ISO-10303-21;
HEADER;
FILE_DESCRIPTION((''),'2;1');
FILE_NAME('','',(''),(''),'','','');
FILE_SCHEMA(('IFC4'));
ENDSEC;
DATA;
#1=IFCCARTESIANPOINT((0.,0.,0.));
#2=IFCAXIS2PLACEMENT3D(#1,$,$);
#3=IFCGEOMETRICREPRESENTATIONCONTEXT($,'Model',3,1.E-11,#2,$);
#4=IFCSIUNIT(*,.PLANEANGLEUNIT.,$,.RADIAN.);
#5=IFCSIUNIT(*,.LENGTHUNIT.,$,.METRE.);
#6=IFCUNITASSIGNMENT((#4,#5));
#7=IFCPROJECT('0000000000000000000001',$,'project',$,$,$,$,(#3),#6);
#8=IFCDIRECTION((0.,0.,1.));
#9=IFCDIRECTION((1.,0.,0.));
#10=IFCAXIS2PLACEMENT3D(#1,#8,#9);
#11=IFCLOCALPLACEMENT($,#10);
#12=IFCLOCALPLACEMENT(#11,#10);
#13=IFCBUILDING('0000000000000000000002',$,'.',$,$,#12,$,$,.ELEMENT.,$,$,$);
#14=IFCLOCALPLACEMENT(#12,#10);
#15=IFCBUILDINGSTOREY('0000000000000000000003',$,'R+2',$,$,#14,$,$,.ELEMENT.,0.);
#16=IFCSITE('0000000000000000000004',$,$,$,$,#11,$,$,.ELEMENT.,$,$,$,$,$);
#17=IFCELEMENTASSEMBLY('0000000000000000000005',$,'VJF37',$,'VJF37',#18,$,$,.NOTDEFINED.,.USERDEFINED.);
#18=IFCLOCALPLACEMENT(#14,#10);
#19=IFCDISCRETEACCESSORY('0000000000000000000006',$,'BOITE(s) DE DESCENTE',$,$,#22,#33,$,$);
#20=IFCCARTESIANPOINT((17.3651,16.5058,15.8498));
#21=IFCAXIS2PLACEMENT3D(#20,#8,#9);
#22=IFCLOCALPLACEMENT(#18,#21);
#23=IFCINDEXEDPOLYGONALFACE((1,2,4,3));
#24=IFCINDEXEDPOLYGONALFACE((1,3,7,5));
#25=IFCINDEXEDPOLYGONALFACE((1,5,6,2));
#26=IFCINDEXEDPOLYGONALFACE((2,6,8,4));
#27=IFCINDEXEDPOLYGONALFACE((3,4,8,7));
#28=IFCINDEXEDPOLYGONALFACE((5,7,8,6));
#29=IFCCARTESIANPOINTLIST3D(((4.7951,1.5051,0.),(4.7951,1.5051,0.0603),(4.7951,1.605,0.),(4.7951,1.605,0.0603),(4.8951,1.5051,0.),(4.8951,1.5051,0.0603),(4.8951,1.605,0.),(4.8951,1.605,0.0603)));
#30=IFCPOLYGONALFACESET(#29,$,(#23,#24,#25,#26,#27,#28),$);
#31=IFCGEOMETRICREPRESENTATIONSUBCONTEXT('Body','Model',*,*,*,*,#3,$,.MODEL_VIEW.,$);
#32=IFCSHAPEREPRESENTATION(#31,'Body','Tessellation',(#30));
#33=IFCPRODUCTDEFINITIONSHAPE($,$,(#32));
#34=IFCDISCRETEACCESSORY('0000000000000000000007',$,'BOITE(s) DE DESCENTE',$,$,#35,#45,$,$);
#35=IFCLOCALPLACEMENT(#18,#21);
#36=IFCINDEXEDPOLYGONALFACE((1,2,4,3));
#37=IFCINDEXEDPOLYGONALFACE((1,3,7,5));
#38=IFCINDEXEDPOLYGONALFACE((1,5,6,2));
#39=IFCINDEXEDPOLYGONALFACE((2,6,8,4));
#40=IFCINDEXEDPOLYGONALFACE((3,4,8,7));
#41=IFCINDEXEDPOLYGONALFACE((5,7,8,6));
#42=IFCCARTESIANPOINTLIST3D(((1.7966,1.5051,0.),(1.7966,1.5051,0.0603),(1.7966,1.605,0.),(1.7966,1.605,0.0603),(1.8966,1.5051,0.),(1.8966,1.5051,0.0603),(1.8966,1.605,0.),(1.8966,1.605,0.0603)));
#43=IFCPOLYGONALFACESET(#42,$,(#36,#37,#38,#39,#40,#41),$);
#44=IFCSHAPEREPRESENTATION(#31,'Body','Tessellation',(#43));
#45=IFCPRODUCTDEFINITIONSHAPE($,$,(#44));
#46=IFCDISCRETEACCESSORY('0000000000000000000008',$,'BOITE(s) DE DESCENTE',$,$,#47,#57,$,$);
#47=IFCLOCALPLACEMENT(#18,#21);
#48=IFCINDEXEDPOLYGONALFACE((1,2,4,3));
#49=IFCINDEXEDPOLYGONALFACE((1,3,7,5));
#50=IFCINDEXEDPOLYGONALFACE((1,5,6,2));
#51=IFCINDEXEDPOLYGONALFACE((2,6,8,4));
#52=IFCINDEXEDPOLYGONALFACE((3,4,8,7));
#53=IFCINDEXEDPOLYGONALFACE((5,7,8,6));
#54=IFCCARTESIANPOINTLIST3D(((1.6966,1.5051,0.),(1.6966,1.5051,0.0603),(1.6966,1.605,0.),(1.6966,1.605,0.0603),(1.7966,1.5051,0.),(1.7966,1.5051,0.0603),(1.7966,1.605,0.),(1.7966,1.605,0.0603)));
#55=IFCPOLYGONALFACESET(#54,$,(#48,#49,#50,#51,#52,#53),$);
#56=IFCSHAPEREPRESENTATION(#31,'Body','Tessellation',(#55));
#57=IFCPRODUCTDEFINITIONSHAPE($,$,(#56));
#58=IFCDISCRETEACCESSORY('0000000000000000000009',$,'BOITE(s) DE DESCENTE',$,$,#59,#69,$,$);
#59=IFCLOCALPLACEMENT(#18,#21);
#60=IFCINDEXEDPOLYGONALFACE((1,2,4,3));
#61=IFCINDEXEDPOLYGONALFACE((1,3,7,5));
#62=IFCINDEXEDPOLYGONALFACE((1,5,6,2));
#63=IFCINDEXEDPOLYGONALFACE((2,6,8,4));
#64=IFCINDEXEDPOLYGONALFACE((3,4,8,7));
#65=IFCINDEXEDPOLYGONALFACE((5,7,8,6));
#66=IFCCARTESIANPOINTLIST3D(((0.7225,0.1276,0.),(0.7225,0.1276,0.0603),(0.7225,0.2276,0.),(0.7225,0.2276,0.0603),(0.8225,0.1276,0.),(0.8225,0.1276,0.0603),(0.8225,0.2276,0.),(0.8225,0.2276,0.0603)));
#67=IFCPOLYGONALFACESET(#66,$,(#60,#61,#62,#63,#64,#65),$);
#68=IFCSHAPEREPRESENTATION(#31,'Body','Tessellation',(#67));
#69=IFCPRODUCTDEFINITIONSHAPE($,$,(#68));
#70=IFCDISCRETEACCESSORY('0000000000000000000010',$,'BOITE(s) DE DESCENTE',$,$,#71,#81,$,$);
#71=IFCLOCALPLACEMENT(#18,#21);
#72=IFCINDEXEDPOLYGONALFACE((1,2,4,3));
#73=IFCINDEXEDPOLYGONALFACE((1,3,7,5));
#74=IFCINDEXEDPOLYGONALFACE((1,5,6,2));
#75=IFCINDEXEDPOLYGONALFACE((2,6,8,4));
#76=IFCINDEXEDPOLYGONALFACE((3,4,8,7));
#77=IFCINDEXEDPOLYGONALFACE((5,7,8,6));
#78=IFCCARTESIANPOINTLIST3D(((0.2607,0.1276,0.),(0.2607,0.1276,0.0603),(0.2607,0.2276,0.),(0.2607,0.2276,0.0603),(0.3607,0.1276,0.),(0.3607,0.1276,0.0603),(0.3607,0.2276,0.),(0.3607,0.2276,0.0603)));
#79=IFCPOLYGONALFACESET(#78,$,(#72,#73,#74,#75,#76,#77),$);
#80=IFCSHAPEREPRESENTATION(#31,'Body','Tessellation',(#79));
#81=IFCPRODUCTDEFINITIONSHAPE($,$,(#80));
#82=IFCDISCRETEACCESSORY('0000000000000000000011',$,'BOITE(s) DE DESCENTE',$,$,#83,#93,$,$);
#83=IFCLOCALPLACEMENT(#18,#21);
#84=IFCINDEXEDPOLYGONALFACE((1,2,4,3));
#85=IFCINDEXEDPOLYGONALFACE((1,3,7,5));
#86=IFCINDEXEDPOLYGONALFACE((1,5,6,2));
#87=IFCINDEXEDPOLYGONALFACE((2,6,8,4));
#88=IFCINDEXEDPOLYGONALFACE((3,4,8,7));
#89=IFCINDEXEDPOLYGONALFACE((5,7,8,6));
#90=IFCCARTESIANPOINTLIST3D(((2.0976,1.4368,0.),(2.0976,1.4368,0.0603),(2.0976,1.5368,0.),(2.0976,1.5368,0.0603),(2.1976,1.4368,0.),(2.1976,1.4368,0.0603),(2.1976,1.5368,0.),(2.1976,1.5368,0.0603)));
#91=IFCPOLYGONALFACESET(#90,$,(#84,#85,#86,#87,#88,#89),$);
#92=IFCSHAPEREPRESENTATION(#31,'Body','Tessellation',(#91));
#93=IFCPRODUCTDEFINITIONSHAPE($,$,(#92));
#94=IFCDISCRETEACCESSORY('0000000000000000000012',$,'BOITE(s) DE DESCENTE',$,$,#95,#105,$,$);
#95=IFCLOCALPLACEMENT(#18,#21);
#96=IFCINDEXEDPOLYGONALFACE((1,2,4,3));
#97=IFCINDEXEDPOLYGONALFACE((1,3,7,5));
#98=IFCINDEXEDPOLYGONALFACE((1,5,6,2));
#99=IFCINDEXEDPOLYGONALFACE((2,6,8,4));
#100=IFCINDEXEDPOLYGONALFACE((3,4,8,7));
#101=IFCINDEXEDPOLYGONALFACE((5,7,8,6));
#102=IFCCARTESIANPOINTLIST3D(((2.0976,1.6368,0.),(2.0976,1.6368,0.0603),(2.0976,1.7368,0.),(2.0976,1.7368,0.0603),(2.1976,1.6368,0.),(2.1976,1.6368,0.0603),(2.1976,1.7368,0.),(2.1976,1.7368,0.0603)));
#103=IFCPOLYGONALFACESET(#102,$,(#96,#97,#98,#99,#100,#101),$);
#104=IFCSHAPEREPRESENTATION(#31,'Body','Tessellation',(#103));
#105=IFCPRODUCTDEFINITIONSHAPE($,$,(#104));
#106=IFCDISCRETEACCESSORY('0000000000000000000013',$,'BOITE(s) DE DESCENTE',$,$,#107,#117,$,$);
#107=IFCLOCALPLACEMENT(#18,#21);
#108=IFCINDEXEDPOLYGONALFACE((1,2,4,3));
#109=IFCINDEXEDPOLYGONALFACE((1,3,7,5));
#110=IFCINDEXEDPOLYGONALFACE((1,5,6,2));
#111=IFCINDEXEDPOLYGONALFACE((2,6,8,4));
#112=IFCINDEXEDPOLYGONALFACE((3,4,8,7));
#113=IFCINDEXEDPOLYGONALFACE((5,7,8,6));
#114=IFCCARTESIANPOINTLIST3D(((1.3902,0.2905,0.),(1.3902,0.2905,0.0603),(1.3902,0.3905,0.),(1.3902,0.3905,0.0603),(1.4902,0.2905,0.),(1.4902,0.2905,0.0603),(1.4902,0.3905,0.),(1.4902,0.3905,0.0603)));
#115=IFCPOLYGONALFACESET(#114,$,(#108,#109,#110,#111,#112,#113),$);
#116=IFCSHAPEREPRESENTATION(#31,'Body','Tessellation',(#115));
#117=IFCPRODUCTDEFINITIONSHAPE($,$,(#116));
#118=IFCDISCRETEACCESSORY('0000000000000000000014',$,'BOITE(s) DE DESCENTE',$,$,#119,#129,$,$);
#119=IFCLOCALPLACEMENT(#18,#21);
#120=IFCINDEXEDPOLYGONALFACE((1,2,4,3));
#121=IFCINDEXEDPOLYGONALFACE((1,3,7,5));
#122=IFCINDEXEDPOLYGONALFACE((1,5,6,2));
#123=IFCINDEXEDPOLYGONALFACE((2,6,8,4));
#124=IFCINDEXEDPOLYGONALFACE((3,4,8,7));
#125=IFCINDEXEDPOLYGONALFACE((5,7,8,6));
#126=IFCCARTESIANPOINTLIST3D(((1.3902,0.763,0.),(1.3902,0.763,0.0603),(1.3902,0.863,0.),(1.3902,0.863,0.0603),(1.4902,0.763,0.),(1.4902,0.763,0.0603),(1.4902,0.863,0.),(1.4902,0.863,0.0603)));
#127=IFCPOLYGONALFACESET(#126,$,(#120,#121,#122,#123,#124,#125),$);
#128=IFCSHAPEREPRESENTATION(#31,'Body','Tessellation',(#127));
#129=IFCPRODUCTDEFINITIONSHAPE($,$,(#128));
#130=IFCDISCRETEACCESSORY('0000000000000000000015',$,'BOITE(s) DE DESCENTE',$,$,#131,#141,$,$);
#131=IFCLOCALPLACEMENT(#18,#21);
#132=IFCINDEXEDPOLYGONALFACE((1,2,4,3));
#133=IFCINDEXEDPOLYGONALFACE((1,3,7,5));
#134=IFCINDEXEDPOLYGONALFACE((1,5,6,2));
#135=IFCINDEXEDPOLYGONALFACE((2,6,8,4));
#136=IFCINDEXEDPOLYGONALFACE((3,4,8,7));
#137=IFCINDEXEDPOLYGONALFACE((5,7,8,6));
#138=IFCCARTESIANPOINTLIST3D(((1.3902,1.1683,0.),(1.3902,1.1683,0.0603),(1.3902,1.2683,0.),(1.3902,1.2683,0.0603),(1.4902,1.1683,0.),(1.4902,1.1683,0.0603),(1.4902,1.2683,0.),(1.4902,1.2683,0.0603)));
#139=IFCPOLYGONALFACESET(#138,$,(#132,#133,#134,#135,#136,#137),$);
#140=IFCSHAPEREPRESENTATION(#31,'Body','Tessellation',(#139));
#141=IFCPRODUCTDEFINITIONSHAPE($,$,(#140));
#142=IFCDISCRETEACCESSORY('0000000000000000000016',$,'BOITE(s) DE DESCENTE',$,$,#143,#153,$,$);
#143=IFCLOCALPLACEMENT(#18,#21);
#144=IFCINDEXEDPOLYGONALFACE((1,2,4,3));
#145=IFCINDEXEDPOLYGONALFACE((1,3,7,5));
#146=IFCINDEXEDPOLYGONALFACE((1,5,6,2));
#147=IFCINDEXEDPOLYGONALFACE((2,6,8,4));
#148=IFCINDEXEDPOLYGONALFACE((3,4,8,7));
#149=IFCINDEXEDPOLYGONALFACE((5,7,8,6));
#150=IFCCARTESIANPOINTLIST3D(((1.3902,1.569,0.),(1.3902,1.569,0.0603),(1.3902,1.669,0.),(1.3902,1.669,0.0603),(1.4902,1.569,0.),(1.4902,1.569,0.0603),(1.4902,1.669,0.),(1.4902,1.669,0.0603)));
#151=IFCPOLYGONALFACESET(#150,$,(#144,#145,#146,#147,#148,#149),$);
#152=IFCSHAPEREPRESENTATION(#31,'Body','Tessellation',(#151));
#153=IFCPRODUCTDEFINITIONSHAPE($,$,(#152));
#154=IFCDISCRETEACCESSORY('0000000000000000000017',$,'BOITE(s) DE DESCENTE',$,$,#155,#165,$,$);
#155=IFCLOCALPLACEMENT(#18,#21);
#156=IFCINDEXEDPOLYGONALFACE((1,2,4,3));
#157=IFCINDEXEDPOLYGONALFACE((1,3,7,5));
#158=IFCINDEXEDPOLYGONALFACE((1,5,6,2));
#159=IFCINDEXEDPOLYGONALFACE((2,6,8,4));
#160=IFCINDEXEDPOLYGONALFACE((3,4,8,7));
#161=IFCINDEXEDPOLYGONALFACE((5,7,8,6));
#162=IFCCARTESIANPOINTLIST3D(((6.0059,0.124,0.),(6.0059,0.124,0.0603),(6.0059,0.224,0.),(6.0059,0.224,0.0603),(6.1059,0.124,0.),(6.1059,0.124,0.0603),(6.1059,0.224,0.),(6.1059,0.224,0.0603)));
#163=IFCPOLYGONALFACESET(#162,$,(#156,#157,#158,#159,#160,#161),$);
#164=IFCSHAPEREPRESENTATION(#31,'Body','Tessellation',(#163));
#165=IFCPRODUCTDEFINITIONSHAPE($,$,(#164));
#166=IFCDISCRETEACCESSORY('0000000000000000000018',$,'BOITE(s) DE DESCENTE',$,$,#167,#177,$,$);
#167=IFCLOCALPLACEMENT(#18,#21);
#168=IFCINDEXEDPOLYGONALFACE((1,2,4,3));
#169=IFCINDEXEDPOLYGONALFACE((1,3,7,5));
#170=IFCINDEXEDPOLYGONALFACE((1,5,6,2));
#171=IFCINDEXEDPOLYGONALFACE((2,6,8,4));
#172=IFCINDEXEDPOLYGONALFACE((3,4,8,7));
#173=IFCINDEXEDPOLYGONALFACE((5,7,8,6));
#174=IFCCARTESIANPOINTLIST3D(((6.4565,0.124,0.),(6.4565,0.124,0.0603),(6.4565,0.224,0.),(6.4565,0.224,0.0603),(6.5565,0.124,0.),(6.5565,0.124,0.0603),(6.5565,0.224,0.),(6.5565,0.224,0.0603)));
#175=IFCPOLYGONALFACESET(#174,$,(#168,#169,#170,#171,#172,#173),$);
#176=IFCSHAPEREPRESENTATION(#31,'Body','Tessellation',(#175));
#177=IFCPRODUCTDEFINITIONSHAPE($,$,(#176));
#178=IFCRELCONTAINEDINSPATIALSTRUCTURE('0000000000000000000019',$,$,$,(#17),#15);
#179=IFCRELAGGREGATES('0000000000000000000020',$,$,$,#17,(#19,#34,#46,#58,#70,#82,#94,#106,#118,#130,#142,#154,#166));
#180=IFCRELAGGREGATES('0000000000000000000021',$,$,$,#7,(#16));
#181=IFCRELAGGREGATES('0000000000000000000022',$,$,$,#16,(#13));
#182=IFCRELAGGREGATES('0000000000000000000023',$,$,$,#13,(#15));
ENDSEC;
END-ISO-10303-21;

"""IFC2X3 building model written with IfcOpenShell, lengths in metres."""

from ifc_helpers import new_model, si_unit, frame, origin, origin_with_axes, place, context, subcontext, project, spatial, polyline, outline, extrude, element, aggregate, save


model = new_model("IFC2X3")

# Units and contexts
model_context = context("Model", 3, precision=1e-11, world=origin())
body_context = subcontext(model_context, "Body", "Model", "MODEL_VIEW")
ifc_project = project(units=[si_unit("PLANEANGLEUNIT", "RADIAN"), si_unit("LENGTHUNIT", "METRE")], contexts=[model_context])

# Site, building, storey
site_placement = place(None, origin_with_axes())
site = spatial("IfcSite", under=ifc_project, at=site_placement, CompositionType="ELEMENT")
building_placement = place(site_placement, origin_with_axes())
building = spatial("IfcBuilding", under=site, at=building_placement, Name=".", CompositionType="ELEMENT")
storey_placement = place(building_placement, origin_with_axes())
storey = spatial("IfcBuildingStorey", under=building, at=storey_placement, Name="R+2", CompositionType="ELEMENT", Elevation=0.0)

# Element assembly, discrete accessories
assembly_placement = place(storey_placement, origin_with_axes())
assembly = element("IfcElementAssembly", 1, at=assembly_placement, inside=storey, Name="VJF37", ObjectType="VJF37", AssemblyPlace="NOTDEFINED", PredefinedType="USERDEFINED")
discrete_accessory_1_placement = place(assembly_placement, frame((17.3651, 16.5058, 15.8498), z_axis=(0.0, 0.0, 1.0), x_axis=(1.0, 0.0, 0.0)))
discrete_accessory_1 = element("IfcDiscreteAccessory", 2, at=discrete_accessory_1_placement, Name="BOITE(s) DE DESCENTE", context=body_context, shape_type="SweptSolid", body=[
    extrude(outline(polyline([(1.505, -4.7951), (1.505, -4.8951), (1.6051, -4.8951), (1.6051, -4.7951), (1.505, -4.7951)])), frame((0.0, 0.0, 0.0), z_axis=(0.0, 0.0, 1.0), x_axis=(0.0, 1.0, 0.0)), (0.0, 0.0, 1.0), 0.0603),
])
discrete_accessory_2_placement = place(assembly_placement, frame((17.3651, 16.5058, 15.8498), z_axis=(0.0, 0.0, 1.0), x_axis=(1.0, 0.0, 0.0)))
discrete_accessory_2 = element("IfcDiscreteAccessory", 3, at=discrete_accessory_2_placement, Name="BOITE(s) DE DESCENTE", context=body_context, shape_type="SweptSolid", body=[
    extrude(outline(polyline([(1.505, -1.7966), (1.505, -1.8966), (1.6051, -1.8966), (1.6051, -1.7966), (1.505, -1.7966)])), frame((0.0, 0.0, 0.0), z_axis=(0.0, 0.0, 1.0), x_axis=(0.0, 1.0, 0.0)), (0.0, 0.0, 1.0), 0.0603),
])
discrete_accessory_3_placement = place(assembly_placement, frame((17.3651, 16.5058, 15.8498), z_axis=(0.0, 0.0, 1.0), x_axis=(1.0, 0.0, 0.0)))
discrete_accessory_3 = element("IfcDiscreteAccessory", 4, at=discrete_accessory_3_placement, Name="BOITE(s) DE DESCENTE", context=body_context, shape_type="SweptSolid", body=[
    extrude(outline(polyline([(1.505, -1.6966), (1.505, -1.7966), (1.6051, -1.7966), (1.6051, -1.6966), (1.505, -1.6966)])), frame((0.0, 0.0, 0.0), z_axis=(0.0, 0.0, 1.0), x_axis=(0.0, 1.0, 0.0)), (0.0, 0.0, 1.0), 0.0603),
])
discrete_accessory_4_placement = place(assembly_placement, frame((17.3651, 16.5058, 15.8498), z_axis=(0.0, 0.0, 1.0), x_axis=(1.0, 0.0, 0.0)))
discrete_accessory_4 = element("IfcDiscreteAccessory", 5, at=discrete_accessory_4_placement, Name="BOITE(s) DE DESCENTE", context=body_context, shape_type="SweptSolid", body=[
    extrude(outline(polyline([(0.1276, -0.7225), (0.1276, -0.8225), (0.2276, -0.8225), (0.2276, -0.7225), (0.1276, -0.7225)])), frame((0.0, 0.0, 0.0), z_axis=(0.0, 0.0, 1.0), x_axis=(0.0, 1.0, 0.0)), (0.0, 0.0, 1.0), 0.0603),
])
discrete_accessory_5_placement = place(assembly_placement, frame((17.3651, 16.5058, 15.8498), z_axis=(0.0, 0.0, 1.0), x_axis=(1.0, 0.0, 0.0)))
discrete_accessory_5 = element("IfcDiscreteAccessory", 6, at=discrete_accessory_5_placement, Name="BOITE(s) DE DESCENTE", context=body_context, shape_type="SweptSolid", body=[
    extrude(outline(polyline([(0.1276, -0.2607), (0.1276, -0.3607), (0.2276, -0.3607), (0.2276, -0.2607), (0.1276, -0.2607)])), frame((0.0, 0.0, 0.0), z_axis=(0.0, 0.0, 1.0), x_axis=(0.0, 1.0, 0.0)), (0.0, 0.0, 1.0), 0.0603),
])
discrete_accessory_6_placement = place(assembly_placement, frame((17.3651, 16.5058, 15.8498), z_axis=(0.0, 0.0, 1.0), x_axis=(1.0, 0.0, 0.0)))
discrete_accessory_6 = element("IfcDiscreteAccessory", 7, at=discrete_accessory_6_placement, Name="BOITE(s) DE DESCENTE", context=body_context, shape_type="SweptSolid", body=[
    extrude(outline(polyline([(1.4368, -2.0976), (1.4368, -2.1976), (1.5368, -2.1976), (1.5368, -2.0976), (1.4368, -2.0976)])), frame((0.0, 0.0, 0.0), z_axis=(0.0, 0.0, 1.0), x_axis=(0.0, 1.0, 0.0)), (0.0, 0.0, 1.0), 0.0603),
])
discrete_accessory_7_placement = place(assembly_placement, frame((17.3651, 16.5058, 15.8498), z_axis=(0.0, 0.0, 1.0), x_axis=(1.0, 0.0, 0.0)))
discrete_accessory_7 = element("IfcDiscreteAccessory", 8, at=discrete_accessory_7_placement, Name="BOITE(s) DE DESCENTE", context=body_context, shape_type="SweptSolid", body=[
    extrude(outline(polyline([(1.6368, -2.0976), (1.6368, -2.1976), (1.7368, -2.1976), (1.7368, -2.0976), (1.6368, -2.0976)])), frame((0.0, 0.0, 0.0), z_axis=(0.0, 0.0, 1.0), x_axis=(0.0, 1.0, 0.0)), (0.0, 0.0, 1.0), 0.0603),
])
discrete_accessory_8_placement = place(assembly_placement, frame((17.3651, 16.5058, 15.8498), z_axis=(0.0, 0.0, 1.0), x_axis=(1.0, 0.0, 0.0)))
discrete_accessory_8 = element("IfcDiscreteAccessory", 9, at=discrete_accessory_8_placement, Name="BOITE(s) DE DESCENTE", context=body_context, shape_type="SweptSolid", body=[
    extrude(outline(polyline([(0.2905, -1.3902), (0.2905, -1.4902), (0.3905, -1.4902), (0.3905, -1.3902), (0.2905, -1.3902)])), frame((0.0, 0.0, 0.0), z_axis=(0.0, 0.0, 1.0), x_axis=(0.0, 1.0, 0.0)), (0.0, 0.0, 1.0), 0.0603),
])
discrete_accessory_9_placement = place(assembly_placement, frame((17.3651, 16.5058, 15.8498), z_axis=(0.0, 0.0, 1.0), x_axis=(1.0, 0.0, 0.0)))
discrete_accessory_9 = element("IfcDiscreteAccessory", 10, at=discrete_accessory_9_placement, Name="BOITE(s) DE DESCENTE", context=body_context, shape_type="SweptSolid", body=[
    extrude(outline(polyline([(0.763, -1.3902), (0.763, -1.4902), (0.863, -1.4902), (0.863, -1.3902), (0.763, -1.3902)])), frame((0.0, 0.0, 0.0), z_axis=(0.0, 0.0, 1.0), x_axis=(0.0, 1.0, 0.0)), (0.0, 0.0, 1.0), 0.0603),
])
discrete_accessory_10_placement = place(assembly_placement, frame((17.3651, 16.5058, 15.8498), z_axis=(0.0, 0.0, 1.0), x_axis=(1.0, 0.0, 0.0)))
discrete_accessory_10 = element("IfcDiscreteAccessory", 11, at=discrete_accessory_10_placement, Name="BOITE(s) DE DESCENTE", context=body_context, shape_type="SweptSolid", body=[
    extrude(outline(polyline([(1.1683, -1.3902), (1.1683, -1.4902), (1.2683, -1.4902), (1.2683, -1.3902), (1.1683, -1.3902)])), frame((0.0, 0.0, 0.0), z_axis=(0.0, 0.0, 1.0), x_axis=(0.0, 1.0, 0.0)), (0.0, 0.0, 1.0), 0.0603),
])
discrete_accessory_11_placement = place(assembly_placement, frame((17.3651, 16.5058, 15.8498), z_axis=(0.0, 0.0, 1.0), x_axis=(1.0, 0.0, 0.0)))
discrete_accessory_11 = element("IfcDiscreteAccessory", 12, at=discrete_accessory_11_placement, Name="BOITE(s) DE DESCENTE", context=body_context, shape_type="SweptSolid", body=[
    extrude(outline(polyline([(1.569, -1.3902), (1.569, -1.4902), (1.669, -1.4902), (1.669, -1.3902), (1.569, -1.3902)])), frame((0.0, 0.0, 0.0), z_axis=(0.0, 0.0, 1.0), x_axis=(0.0, 1.0, 0.0)), (0.0, 0.0, 1.0), 0.0603),
])
discrete_accessory_12_placement = place(assembly_placement, frame((17.3651, 16.5058, 15.8498), z_axis=(0.0, 0.0, 1.0), x_axis=(1.0, 0.0, 0.0)))
discrete_accessory_12 = element("IfcDiscreteAccessory", 13, at=discrete_accessory_12_placement, Name="BOITE(s) DE DESCENTE", context=body_context, shape_type="SweptSolid", body=[
    extrude(outline(polyline([(0.124, -6.0059), (0.124, -6.1059), (0.224, -6.1059), (0.224, -6.0059), (0.124, -6.0059)])), frame((0.0, 0.0, 0.0), z_axis=(0.0, 0.0, 1.0), x_axis=(0.0, 1.0, 0.0)), (0.0, 0.0, 1.0), 0.0603),
])
discrete_accessory_13_placement = place(assembly_placement, frame((17.3651, 16.5058, 15.8498), z_axis=(0.0, 0.0, 1.0), x_axis=(1.0, 0.0, 0.0)))
discrete_accessory_13 = element("IfcDiscreteAccessory", 14, at=discrete_accessory_13_placement, Name="BOITE(s) DE DESCENTE", context=body_context, shape_type="SweptSolid", body=[
    extrude(outline(polyline([(0.124, -6.4565), (0.124, -6.5565), (0.224, -6.5565), (0.224, -6.4565), (0.124, -6.4565)])), frame((0.0, 0.0, 0.0), z_axis=(0.0, 0.0, 1.0), x_axis=(0.0, 1.0, 0.0)), (0.0, 0.0, 1.0), 0.0603),
])
aggregate(assembly, [discrete_accessory_1, discrete_accessory_2, discrete_accessory_3, discrete_accessory_4, discrete_accessory_5, discrete_accessory_6, discrete_accessory_7, discrete_accessory_8, discrete_accessory_9, discrete_accessory_10, discrete_accessory_11, discrete_accessory_12, discrete_accessory_13])

save(model, "model.ifc")
